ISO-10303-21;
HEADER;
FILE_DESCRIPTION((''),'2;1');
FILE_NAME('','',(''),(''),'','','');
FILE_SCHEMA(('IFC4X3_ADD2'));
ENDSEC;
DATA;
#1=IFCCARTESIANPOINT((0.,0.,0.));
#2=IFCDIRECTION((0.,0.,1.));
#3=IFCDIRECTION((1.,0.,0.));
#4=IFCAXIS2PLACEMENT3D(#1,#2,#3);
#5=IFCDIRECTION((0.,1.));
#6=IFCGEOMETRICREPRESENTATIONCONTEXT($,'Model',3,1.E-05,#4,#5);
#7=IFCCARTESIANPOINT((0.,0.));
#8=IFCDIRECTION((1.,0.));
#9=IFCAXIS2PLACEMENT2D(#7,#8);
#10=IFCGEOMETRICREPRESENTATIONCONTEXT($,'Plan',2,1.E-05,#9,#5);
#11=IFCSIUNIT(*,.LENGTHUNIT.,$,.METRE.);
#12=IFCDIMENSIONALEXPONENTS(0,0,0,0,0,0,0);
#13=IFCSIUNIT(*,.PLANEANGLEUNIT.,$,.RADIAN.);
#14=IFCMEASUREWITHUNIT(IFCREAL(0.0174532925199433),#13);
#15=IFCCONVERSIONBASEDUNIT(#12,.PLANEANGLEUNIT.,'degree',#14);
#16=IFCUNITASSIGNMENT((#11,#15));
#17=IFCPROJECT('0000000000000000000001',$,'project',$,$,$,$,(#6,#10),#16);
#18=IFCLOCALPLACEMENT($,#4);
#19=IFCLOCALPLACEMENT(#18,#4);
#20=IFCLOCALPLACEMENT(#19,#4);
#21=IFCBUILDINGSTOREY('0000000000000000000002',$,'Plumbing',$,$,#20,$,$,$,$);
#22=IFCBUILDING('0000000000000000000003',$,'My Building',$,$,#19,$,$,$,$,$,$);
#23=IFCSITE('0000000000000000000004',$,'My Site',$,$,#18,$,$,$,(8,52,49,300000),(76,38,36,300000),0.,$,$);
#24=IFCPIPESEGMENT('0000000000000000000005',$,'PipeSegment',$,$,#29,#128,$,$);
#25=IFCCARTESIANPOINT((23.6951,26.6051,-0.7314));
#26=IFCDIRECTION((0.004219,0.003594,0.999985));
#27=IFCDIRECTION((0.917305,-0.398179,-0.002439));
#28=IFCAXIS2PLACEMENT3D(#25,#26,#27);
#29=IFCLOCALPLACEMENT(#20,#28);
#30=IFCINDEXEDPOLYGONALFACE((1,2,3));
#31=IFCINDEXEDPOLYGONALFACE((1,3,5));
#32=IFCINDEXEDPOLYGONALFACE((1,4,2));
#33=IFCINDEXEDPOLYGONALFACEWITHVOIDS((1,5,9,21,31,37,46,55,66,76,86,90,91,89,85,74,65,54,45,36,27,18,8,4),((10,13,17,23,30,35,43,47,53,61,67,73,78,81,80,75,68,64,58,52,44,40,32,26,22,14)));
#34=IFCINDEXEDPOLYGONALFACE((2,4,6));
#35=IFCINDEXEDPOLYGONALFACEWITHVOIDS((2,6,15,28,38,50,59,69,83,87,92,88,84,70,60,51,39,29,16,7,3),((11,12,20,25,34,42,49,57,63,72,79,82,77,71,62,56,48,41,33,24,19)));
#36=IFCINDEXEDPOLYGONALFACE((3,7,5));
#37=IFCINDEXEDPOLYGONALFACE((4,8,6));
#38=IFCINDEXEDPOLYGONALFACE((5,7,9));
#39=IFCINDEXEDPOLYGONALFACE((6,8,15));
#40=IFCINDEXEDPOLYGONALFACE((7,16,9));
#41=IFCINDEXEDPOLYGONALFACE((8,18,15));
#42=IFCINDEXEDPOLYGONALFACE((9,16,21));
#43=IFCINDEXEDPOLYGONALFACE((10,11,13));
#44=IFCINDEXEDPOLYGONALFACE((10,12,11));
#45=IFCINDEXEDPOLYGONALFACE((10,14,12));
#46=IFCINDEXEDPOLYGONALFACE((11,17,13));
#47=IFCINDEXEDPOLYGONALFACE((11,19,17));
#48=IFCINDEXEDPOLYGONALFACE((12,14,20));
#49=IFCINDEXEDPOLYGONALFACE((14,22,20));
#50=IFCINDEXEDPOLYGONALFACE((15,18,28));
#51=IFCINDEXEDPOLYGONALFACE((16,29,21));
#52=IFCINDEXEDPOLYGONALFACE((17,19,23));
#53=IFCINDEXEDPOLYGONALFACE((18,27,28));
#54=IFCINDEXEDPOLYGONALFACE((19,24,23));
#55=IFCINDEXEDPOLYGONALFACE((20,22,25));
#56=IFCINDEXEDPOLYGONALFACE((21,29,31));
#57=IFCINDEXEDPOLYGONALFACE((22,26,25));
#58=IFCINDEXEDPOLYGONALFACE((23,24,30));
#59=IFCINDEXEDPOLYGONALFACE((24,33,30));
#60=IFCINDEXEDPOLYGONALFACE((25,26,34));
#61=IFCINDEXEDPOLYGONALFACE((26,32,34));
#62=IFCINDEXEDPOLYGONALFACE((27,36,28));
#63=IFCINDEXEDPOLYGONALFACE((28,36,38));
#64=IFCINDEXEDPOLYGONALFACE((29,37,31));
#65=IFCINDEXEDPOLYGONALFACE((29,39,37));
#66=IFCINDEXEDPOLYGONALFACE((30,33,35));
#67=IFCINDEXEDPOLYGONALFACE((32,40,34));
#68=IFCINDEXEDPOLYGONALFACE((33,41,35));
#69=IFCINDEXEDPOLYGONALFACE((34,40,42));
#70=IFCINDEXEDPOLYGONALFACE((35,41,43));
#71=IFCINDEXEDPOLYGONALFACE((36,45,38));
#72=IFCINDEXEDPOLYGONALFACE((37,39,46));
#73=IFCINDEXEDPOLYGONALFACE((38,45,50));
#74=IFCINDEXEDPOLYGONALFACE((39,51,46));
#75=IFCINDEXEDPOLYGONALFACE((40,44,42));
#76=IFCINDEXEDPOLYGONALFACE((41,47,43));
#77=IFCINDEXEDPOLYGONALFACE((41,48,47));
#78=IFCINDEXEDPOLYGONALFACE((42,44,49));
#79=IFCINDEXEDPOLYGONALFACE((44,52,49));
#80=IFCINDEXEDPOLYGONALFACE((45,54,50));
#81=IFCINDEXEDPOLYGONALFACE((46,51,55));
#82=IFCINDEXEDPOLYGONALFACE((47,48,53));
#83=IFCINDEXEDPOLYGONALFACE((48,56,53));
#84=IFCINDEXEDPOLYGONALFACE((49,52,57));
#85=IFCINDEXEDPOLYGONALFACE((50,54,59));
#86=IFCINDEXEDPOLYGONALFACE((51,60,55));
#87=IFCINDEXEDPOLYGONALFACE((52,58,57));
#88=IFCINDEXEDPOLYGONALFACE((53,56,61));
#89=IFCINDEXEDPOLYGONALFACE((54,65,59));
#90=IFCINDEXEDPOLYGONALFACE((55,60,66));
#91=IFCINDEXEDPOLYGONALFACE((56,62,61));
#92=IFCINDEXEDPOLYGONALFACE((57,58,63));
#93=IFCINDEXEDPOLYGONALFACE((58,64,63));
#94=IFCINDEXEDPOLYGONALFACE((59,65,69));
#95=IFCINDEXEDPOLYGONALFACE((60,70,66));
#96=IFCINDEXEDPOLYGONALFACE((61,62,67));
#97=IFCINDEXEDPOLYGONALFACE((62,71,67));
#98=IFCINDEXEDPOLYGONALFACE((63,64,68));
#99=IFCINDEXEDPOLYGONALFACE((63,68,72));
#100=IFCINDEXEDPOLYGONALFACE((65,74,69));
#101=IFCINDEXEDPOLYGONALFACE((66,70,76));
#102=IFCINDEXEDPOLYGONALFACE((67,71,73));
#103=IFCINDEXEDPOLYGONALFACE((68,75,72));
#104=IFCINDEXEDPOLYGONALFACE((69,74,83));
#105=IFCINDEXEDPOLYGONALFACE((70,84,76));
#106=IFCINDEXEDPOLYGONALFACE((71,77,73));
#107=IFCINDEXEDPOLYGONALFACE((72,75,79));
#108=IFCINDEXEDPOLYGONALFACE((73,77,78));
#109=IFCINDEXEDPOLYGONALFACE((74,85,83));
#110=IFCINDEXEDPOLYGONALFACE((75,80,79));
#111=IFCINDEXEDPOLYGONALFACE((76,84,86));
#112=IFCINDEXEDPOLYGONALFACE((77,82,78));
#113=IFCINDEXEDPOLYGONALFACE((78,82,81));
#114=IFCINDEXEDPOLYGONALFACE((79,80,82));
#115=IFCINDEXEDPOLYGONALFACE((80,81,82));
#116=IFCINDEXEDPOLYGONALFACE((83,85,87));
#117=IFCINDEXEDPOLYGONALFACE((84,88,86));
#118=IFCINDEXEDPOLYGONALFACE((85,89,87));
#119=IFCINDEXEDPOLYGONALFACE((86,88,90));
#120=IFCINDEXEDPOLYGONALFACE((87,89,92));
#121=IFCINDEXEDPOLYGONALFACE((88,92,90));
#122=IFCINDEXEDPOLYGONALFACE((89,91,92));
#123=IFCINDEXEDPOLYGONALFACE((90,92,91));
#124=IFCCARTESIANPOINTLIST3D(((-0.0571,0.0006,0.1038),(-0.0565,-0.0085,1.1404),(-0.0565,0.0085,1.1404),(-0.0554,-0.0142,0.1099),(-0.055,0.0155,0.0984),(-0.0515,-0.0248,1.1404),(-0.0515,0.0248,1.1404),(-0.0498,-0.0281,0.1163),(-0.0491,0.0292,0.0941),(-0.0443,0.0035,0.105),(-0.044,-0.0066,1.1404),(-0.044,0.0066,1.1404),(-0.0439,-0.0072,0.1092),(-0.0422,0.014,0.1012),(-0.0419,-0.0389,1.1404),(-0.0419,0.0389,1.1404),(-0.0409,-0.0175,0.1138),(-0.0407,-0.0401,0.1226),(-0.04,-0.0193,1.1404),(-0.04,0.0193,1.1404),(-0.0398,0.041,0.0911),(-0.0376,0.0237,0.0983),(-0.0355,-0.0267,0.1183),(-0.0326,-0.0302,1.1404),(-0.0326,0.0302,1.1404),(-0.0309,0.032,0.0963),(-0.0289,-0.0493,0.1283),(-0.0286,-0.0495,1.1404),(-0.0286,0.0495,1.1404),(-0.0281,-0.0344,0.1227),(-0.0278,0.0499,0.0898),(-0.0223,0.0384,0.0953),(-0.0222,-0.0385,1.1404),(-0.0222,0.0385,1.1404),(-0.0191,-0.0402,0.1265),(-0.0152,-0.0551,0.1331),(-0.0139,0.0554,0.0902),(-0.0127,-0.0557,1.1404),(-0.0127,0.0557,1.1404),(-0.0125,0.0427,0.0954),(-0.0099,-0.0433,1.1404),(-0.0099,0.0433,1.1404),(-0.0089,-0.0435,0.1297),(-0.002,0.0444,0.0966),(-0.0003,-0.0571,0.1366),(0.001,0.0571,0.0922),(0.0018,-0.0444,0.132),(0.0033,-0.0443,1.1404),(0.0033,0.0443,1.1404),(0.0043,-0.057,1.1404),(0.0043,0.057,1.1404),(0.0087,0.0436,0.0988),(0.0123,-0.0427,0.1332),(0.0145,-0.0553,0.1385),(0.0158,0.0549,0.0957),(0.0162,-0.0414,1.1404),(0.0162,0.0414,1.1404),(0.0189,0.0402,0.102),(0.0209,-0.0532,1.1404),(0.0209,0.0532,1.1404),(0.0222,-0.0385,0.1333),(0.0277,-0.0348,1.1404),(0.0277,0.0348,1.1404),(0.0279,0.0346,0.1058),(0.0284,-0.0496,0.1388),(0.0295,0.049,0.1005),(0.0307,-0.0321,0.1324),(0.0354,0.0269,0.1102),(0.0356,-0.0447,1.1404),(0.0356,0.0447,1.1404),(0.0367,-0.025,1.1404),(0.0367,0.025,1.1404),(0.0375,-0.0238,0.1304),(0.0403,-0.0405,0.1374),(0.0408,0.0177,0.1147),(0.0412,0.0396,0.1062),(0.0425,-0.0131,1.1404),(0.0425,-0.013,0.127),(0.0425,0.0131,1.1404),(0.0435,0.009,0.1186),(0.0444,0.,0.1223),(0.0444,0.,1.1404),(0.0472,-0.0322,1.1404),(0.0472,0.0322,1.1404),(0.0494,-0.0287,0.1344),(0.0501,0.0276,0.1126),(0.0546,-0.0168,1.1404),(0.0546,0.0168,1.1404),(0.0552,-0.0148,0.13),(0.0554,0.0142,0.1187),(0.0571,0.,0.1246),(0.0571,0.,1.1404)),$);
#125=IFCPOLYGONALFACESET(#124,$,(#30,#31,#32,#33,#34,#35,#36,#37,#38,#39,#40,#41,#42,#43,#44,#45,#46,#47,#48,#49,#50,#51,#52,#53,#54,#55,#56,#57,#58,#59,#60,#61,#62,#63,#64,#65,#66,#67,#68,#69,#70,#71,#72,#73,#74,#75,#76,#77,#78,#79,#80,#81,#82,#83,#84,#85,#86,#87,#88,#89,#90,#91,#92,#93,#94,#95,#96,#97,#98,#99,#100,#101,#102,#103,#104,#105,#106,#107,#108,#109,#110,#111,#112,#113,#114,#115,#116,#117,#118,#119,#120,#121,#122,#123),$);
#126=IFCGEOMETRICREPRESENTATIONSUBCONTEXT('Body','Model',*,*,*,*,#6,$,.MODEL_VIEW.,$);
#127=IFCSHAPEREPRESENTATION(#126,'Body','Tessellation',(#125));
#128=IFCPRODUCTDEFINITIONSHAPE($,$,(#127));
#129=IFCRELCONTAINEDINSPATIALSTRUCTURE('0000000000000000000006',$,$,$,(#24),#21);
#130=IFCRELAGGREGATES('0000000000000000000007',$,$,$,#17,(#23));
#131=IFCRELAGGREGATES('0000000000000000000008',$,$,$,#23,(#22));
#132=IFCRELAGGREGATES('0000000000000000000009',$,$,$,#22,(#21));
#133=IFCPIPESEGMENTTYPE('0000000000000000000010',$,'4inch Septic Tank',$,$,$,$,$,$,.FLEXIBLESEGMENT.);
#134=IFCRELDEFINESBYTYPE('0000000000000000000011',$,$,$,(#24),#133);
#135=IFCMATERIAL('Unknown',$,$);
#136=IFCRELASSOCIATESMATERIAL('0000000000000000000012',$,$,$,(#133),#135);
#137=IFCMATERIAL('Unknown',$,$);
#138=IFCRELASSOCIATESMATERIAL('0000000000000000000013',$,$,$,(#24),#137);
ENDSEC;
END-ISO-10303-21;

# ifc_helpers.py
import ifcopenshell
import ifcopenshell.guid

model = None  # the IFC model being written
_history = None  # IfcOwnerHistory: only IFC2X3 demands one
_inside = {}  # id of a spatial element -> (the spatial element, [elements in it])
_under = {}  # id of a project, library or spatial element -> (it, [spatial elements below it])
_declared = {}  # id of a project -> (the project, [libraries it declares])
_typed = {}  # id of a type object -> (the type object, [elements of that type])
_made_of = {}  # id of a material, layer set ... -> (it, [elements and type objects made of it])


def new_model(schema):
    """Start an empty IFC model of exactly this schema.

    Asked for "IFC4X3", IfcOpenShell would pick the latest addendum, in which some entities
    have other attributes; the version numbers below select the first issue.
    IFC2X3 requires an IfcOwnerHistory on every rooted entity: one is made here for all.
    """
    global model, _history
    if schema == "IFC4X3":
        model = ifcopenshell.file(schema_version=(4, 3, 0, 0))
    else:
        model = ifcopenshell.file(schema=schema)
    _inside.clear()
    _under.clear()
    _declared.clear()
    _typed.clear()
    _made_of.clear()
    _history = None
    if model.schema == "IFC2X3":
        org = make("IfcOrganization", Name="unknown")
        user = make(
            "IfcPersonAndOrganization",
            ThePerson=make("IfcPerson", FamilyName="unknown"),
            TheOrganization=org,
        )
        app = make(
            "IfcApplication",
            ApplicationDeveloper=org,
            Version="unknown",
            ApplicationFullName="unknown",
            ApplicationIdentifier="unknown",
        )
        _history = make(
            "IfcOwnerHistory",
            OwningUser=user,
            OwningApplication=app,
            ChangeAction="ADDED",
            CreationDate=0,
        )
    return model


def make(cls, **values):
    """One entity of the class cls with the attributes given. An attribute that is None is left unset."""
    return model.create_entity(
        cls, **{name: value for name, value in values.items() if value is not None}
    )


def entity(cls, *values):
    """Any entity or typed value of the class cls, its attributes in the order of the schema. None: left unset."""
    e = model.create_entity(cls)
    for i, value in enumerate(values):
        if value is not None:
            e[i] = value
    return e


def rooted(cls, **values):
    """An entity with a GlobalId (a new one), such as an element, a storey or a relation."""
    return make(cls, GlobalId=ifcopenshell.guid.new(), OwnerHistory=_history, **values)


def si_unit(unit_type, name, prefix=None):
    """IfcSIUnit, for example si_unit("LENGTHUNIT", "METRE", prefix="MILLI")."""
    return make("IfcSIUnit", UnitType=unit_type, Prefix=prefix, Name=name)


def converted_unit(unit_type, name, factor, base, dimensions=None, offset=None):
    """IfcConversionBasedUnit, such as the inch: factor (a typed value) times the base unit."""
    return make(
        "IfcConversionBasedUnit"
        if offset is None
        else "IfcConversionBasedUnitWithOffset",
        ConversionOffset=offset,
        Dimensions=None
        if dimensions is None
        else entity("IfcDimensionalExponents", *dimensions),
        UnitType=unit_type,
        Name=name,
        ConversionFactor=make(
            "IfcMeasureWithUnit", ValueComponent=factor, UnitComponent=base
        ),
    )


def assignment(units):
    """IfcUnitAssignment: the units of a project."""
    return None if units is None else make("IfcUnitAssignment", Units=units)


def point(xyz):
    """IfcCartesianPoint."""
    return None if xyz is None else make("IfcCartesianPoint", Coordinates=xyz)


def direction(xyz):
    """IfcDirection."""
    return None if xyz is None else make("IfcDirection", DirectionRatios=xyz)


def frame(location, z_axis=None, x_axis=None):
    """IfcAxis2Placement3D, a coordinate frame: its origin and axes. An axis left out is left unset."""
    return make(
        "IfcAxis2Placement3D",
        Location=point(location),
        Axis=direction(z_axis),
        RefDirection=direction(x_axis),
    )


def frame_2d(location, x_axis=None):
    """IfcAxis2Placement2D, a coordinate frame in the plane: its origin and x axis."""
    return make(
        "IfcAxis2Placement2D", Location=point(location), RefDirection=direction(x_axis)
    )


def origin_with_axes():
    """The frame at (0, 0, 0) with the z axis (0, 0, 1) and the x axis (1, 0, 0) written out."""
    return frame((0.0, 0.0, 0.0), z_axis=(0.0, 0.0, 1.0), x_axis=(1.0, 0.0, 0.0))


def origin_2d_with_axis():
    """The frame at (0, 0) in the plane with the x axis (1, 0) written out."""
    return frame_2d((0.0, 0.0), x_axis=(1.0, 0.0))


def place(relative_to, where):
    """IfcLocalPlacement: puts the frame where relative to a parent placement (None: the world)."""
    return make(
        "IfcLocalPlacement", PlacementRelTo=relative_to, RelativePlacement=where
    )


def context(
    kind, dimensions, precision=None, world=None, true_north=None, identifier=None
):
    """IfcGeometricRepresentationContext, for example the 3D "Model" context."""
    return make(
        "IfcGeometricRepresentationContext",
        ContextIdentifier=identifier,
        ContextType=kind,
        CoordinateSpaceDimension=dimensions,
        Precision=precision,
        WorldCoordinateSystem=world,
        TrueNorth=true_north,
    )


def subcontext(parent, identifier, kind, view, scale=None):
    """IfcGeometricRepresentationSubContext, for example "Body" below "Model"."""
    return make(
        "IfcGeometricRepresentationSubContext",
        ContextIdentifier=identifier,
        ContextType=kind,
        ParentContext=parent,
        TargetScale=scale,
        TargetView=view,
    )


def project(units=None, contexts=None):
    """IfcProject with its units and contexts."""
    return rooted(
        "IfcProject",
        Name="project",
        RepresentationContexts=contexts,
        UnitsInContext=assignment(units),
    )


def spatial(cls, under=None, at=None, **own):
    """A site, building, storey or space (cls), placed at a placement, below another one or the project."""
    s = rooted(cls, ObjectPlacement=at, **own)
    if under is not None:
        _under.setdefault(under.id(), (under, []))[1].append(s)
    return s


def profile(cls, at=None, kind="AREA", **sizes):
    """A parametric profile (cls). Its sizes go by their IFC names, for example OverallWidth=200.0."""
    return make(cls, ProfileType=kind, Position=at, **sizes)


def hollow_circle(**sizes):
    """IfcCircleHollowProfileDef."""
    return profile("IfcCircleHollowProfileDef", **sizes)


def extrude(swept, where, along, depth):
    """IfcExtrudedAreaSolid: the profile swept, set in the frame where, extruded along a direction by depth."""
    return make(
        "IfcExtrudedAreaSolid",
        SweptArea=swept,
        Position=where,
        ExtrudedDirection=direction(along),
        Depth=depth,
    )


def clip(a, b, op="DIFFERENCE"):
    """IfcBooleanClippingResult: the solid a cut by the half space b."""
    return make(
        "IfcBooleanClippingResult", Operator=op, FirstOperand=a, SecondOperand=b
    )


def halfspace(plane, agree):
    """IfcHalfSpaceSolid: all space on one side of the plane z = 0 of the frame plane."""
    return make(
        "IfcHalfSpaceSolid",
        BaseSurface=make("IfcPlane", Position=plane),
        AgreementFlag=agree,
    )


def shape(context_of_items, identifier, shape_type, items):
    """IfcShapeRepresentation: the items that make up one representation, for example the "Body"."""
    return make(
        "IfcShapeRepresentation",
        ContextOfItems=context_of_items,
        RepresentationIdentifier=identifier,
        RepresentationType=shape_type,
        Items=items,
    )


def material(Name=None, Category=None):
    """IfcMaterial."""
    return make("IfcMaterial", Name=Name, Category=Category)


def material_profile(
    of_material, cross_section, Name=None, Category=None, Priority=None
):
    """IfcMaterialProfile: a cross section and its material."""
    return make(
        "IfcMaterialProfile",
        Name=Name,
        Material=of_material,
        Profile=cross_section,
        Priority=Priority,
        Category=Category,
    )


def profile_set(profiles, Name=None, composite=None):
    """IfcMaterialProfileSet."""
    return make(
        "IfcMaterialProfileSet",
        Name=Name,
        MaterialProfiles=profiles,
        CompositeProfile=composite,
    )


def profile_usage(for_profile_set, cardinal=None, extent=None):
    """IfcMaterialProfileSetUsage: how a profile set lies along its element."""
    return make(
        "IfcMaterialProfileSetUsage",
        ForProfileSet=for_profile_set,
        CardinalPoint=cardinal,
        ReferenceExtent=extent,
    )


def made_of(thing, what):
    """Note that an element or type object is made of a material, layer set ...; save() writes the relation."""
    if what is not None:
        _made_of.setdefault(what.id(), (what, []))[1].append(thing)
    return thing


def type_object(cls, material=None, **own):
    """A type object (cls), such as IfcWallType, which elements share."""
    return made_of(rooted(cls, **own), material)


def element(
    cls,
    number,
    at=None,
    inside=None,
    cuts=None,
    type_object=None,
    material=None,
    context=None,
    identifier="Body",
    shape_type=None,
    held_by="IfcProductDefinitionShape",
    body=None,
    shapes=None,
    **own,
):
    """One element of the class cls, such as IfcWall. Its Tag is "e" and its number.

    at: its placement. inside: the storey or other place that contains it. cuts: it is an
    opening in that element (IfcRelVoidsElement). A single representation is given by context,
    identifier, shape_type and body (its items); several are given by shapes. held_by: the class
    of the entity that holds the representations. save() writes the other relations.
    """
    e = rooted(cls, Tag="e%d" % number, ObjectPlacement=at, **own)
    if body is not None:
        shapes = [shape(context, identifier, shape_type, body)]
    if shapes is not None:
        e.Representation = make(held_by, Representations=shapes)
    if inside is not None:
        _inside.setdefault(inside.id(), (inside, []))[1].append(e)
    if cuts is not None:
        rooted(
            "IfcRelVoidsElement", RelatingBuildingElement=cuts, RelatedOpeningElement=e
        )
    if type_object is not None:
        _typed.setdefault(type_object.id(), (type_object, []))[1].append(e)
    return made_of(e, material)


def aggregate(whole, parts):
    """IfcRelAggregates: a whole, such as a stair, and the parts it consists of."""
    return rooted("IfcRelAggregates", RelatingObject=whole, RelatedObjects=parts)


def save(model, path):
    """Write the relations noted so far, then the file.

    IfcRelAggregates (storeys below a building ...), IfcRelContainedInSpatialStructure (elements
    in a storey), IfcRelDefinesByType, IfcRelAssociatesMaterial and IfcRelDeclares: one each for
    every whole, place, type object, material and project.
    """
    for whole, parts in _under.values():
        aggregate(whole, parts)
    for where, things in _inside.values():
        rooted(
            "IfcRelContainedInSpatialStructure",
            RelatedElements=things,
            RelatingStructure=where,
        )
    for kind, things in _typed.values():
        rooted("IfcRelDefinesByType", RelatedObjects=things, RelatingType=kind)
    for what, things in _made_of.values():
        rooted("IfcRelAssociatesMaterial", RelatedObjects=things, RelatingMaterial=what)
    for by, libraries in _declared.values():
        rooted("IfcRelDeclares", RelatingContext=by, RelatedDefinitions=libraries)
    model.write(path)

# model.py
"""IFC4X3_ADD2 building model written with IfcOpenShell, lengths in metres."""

from ifc_helpers import new_model, entity, si_unit, converted_unit, direction, frame, origin_with_axes, origin_2d_with_axis, place, context, subcontext, project, spatial, hollow_circle, extrude, clip, halfspace, material, material_profile, profile_set, profile_usage, type_object, element, save


model = new_model("IFC4X3_ADD2")

# Units and contexts
model_context = context("Model", 3, precision=1e-05, world=origin_with_axes(), true_north=direction((0.0, 1.0)))
plan_context = context("Plan", 2, precision=1e-05, world=origin_2d_with_axis(), true_north=direction((0.0, 1.0)))
body_context = subcontext(model_context, "Body", "Model", "MODEL_VIEW")
ifc_project = project(units=[si_unit("LENGTHUNIT", "METRE"), converted_unit("PLANEANGLEUNIT", "degree", entity("IfcReal", 0.0174532925199433), si_unit("PLANEANGLEUNIT", "RADIAN"), dimensions=[0, 0, 0, 0, 0, 0, 0])], contexts=[model_context, plan_context])

# Site, building, storey
site_placement = place(None, origin_with_axes())
site = spatial("IfcSite", under=ifc_project, at=site_placement, Name="My Site", RefLatitude=(8, 52, 49, 300000), RefLongitude=(76, 38, 36, 300000), RefElevation=0.0)
building_placement = place(site_placement, origin_with_axes())
building = spatial("IfcBuilding", under=site, at=building_placement, Name="My Building")
storey_placement = place(building_placement, origin_with_axes())
storey = spatial("IfcBuildingStorey", under=building, at=storey_placement, Name="Plumbing")

# Pipe segment
ifc_material_1 = material(Name="Unknown")
ifc_material_profile_1 = material_profile(ifc_material_1, hollow_circle(Radius=0.0571, WallThickness=0.0127))
ifc_profile_set_1 = profile_set([ifc_material_profile_1], Name="blackwater")
ifc_material_2 = material(Name="Unknown")
ifc_material_profile_2 = material_profile(ifc_material_2, hollow_circle(Radius=0.0571, WallThickness=0.0127))
ifc_profile_set_2 = profile_set([ifc_material_profile_2], Name="blackwater")
pipe_segment_type_1 = type_object("IfcPipeSegmentType", Name="4inch Septic Tank", PredefinedType="FLEXIBLESEGMENT", material=ifc_profile_set_2)
ifc_profile_usage_1 = profile_usage(ifc_profile_set_1, cardinal=5)
pipe_segment_1_placement = place(storey_placement, frame((23.6951, 26.6051, -0.7314), z_axis=(0.004219, 0.003594, 0.999985), x_axis=(0.917305, -0.398179, -0.002439)))
element("IfcPipeSegment", 1, at=pipe_segment_1_placement, inside=storey, type_object=pipe_segment_type_1, material=ifc_profile_usage_1, Name="PipeSegment", context=body_context, shape_type="Clipping", body=[
    clip(extrude(hollow_circle(Radius=0.0571, WallThickness=0.0127), origin_with_axes(), (0.0, 0.0, 1.0), 1.1404), halfspace(frame((-0.1712, -0.0565, 0.1055), z_axis=(0.165343, -0.358689, -0.918697), x_axis=(-0.908157, -0.418629, 0.0)), False)),
])

save(model, "model.ifc")
